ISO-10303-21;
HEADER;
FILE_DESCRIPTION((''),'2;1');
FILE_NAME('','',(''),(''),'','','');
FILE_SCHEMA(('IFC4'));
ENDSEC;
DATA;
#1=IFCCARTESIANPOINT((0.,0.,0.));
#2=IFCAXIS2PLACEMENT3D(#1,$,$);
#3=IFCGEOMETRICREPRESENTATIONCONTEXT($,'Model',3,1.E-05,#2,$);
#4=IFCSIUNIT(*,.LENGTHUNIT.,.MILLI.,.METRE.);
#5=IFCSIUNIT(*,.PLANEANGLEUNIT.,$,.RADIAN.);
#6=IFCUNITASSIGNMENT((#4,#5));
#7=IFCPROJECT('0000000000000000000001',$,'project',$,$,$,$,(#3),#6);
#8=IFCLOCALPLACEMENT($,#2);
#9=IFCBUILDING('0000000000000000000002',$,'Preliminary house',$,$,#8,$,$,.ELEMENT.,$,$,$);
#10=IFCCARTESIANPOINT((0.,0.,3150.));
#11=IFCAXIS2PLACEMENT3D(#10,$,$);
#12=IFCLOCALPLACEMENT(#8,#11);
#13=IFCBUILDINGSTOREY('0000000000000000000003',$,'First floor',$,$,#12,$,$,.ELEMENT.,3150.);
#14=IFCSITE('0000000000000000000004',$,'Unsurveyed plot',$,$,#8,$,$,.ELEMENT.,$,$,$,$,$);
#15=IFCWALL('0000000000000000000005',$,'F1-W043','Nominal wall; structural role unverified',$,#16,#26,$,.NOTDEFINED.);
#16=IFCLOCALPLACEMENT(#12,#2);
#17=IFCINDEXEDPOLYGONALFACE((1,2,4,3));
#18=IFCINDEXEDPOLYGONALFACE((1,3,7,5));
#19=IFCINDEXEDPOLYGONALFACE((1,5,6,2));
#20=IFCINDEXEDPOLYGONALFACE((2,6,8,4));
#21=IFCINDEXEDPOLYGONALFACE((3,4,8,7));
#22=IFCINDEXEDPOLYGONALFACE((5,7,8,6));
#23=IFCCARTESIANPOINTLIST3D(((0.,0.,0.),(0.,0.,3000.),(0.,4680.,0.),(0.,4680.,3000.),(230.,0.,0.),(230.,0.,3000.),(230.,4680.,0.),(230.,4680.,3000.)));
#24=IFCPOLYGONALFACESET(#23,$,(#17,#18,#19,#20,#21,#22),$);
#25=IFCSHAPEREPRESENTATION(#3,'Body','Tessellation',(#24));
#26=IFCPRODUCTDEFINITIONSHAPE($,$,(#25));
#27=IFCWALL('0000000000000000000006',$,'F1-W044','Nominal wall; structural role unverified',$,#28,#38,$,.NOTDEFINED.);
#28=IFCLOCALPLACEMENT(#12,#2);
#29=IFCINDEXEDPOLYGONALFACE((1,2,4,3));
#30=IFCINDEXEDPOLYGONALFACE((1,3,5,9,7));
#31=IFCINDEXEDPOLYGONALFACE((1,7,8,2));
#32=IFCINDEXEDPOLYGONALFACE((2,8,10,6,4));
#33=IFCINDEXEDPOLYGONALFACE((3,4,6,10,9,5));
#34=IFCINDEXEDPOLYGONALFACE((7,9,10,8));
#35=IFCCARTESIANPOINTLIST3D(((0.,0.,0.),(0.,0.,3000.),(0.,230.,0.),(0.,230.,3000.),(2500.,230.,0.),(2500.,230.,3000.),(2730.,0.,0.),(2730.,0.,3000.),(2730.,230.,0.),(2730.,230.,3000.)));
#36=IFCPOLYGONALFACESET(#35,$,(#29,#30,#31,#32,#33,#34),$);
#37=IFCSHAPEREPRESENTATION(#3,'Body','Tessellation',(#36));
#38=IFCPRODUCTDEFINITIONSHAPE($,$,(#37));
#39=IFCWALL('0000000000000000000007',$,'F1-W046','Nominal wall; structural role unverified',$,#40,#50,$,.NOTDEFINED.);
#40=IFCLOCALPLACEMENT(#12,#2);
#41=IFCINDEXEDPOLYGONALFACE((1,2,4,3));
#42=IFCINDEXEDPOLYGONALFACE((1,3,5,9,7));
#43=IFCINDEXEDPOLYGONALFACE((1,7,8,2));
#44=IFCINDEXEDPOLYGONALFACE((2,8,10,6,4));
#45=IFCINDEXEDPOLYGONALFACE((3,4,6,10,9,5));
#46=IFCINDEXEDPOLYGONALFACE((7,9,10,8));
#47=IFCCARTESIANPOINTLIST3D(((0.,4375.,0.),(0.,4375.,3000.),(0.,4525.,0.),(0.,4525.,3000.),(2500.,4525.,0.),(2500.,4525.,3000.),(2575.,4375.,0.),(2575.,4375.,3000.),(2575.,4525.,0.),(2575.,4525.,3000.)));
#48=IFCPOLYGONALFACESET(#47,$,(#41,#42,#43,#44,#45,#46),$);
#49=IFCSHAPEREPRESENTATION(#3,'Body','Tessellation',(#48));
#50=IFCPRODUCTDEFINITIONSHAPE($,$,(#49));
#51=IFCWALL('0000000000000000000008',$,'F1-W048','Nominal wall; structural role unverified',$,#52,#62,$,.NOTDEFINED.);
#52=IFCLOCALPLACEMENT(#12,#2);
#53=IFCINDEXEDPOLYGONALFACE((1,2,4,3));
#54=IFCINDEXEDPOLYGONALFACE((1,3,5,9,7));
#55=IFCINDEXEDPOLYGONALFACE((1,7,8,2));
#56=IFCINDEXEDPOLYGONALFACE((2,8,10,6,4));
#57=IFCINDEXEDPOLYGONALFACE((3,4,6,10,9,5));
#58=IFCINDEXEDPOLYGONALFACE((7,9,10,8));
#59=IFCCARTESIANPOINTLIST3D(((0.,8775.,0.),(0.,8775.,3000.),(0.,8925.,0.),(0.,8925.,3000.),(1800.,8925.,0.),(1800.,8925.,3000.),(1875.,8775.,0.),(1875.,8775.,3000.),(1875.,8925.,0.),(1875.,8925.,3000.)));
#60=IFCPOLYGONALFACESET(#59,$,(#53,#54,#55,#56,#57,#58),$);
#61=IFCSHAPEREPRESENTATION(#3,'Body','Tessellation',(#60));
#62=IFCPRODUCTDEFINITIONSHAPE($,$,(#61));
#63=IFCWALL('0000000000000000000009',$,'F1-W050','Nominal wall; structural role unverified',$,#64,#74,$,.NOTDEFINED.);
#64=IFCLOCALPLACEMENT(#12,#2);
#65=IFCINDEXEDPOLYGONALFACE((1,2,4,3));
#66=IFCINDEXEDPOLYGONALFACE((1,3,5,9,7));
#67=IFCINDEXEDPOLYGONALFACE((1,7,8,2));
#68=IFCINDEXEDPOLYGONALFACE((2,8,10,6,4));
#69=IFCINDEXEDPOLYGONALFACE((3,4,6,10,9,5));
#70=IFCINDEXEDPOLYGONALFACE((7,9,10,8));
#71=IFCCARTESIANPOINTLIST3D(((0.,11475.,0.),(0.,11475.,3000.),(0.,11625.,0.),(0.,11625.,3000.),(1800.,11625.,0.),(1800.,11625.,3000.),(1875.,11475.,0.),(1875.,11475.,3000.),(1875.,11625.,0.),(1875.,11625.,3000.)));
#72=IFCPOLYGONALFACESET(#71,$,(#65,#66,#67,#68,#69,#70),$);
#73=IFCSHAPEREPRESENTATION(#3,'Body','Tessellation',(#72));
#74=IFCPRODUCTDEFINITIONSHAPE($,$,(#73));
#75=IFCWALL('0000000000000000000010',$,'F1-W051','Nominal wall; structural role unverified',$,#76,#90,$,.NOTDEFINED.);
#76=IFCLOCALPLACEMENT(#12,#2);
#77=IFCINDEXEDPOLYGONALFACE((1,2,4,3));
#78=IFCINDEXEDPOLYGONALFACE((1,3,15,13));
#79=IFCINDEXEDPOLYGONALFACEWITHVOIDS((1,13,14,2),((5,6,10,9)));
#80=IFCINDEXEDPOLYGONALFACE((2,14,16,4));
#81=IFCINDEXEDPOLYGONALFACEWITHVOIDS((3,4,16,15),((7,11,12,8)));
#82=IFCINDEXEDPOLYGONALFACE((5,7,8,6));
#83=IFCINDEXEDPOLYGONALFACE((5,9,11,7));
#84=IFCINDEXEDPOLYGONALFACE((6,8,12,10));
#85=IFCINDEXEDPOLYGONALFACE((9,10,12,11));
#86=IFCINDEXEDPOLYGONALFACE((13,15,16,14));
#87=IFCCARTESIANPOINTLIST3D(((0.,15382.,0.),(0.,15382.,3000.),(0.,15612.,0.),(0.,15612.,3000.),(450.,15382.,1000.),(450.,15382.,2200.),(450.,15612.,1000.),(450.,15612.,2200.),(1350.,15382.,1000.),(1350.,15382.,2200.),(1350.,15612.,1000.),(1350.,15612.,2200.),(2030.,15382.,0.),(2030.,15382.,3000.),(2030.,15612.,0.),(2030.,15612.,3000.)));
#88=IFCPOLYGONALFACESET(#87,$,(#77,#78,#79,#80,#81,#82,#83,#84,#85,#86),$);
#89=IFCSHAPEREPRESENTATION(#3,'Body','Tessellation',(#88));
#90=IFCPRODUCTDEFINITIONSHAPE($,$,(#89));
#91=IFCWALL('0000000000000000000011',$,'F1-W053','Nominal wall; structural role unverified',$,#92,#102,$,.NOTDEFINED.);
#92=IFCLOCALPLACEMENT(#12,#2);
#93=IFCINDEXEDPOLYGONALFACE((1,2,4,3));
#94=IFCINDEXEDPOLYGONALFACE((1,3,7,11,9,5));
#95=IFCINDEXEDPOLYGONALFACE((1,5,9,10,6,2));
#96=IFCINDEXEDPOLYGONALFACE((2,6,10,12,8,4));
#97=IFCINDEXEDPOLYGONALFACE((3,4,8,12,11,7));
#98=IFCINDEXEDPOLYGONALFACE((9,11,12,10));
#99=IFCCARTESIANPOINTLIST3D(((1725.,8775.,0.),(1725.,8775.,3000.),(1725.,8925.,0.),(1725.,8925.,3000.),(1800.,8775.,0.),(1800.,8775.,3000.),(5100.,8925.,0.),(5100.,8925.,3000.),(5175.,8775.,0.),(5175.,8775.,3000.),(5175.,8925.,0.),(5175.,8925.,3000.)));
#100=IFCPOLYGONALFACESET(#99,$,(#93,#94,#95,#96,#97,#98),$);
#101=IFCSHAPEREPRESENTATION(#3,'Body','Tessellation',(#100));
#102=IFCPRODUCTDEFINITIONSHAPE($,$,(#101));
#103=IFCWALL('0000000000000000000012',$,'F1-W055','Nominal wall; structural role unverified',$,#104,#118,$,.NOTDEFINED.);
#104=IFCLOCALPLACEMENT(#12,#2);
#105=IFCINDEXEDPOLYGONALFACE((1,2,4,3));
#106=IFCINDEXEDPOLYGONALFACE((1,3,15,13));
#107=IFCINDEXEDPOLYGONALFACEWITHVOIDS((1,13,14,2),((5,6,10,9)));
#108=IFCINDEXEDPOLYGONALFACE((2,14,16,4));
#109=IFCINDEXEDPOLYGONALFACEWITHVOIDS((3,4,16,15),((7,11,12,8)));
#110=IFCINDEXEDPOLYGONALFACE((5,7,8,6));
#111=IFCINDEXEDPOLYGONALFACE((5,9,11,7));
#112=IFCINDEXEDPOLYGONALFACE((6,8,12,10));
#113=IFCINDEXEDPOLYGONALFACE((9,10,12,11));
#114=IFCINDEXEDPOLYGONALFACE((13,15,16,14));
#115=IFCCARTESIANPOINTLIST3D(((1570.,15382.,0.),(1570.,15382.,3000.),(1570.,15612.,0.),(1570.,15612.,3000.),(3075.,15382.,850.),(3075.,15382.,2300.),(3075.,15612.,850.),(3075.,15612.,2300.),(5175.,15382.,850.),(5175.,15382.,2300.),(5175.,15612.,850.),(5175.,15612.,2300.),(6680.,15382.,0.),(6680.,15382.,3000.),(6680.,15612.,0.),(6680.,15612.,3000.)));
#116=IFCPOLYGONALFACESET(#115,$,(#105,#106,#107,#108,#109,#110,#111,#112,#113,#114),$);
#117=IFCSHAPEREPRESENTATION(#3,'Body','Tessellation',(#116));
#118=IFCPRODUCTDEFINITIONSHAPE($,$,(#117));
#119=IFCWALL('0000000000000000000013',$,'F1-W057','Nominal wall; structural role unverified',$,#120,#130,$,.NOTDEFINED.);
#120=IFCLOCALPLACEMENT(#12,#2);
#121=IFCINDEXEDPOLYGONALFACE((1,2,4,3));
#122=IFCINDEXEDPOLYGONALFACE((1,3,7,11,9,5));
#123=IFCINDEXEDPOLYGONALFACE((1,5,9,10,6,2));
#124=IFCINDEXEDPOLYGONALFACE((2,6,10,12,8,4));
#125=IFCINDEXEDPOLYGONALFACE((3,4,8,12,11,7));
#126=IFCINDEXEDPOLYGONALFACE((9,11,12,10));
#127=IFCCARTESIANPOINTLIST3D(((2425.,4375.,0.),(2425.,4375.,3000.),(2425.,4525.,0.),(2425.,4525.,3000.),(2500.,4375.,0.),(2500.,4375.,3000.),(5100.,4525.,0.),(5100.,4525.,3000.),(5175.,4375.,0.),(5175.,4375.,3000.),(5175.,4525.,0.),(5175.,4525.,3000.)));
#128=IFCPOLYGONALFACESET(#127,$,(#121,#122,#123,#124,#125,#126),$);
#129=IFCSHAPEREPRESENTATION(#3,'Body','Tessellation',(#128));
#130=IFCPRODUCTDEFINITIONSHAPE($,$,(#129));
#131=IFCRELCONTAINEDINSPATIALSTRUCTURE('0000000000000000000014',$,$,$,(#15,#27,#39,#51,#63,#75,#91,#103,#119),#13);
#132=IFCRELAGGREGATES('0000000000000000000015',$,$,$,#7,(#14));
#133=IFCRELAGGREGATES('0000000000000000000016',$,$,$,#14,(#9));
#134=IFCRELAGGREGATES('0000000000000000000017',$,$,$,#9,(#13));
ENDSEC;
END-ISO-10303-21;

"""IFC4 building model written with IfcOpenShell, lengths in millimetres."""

from ifc_helpers import new_model, si_unit, frame, origin, place, context, project, spatial, polyline, outline, extrude, element, save


model = new_model("IFC4")

# Units and contexts
model_context = context("Model", 3, precision=1e-05, world=origin())
ifc_project = project(units=[si_unit("LENGTHUNIT", "METRE", prefix="MILLI"), si_unit("PLANEANGLEUNIT", "RADIAN")], contexts=[model_context])

# Site, building, storey
placement_1 = place(None, origin())
site = spatial("IfcSite", under=ifc_project, at=placement_1, Name="Unsurveyed plot", CompositionType="ELEMENT")
building = spatial("IfcBuilding", under=site, at=placement_1, Name="Preliminary house", CompositionType="ELEMENT")
placement_2 = place(placement_1, frame((0.0, 0.0, 3150.0)))
storey = spatial("IfcBuildingStorey", under=building, at=placement_2, Name="First floor", CompositionType="ELEMENT", Elevation=3150.0)

# Walls
element("IfcWall", 1, at=placement_2, inside=storey, Name="F1-W043", Description="Nominal wall; structural role unverified", PredefinedType="NOTDEFINED", context=model_context, shape_type="SweptSolid", body=[
    extrude(outline(polyline([(230.0, 4680.0), (230.0, 0.0), (0.0, 0.0), (0.0, 4680.0), (230.0, 4680.0)])), origin(), (0.0, 0.0, 1.0), 3000.0),
])
element("IfcWall", 2, at=placement_2, inside=storey, Name="F1-W044", Description="Nominal wall; structural role unverified", PredefinedType="NOTDEFINED", context=model_context, shape_type="SweptSolid", body=[
    extrude(outline(polyline([(2730.0, 230.0), (2730.0, 0.0), (0.0, 0.0), (0.0, 230.0), (2500.0, 230.0), (2730.0, 230.0)])), origin(), (0.0, 0.0, 1.0), 3000.0),
])

# Wall
element("IfcWall", 3, at=placement_2, inside=storey, Name="F1-W046", Description="Nominal wall; structural role unverified", PredefinedType="NOTDEFINED", context=model_context, shape_type="SweptSolid", body=[
    extrude(outline(polyline([(2575.0, 4525.0), (2575.0, 4375.0), (0.0, 4375.0), (0.0, 4525.0), (2500.0, 4525.0), (2575.0, 4525.0)])), origin(), (0.0, 0.0, 1.0), 3000.0),
])

# Wall
element("IfcWall", 4, at=placement_2, inside=storey, Name="F1-W048", Description="Nominal wall; structural role unverified", PredefinedType="NOTDEFINED", context=model_context, shape_type="SweptSolid", body=[
    extrude(outline(polyline([(1875.0, 8925.0), (1875.0, 8775.0), (0.0, 8775.0), (0.0, 8925.0), (1800.0, 8925.0), (1875.0, 8925.0)])), origin(), (0.0, 0.0, 1.0), 3000.0),
])

# Wall
element("IfcWall", 5, at=placement_2, inside=storey, Name="F1-W050", Description="Nominal wall; structural role unverified", PredefinedType="NOTDEFINED", context=model_context, shape_type="SweptSolid", body=[
    extrude(outline(polyline([(1875.0, 11625.0), (1875.0, 11475.0), (0.0, 11475.0), (0.0, 11625.0), (1800.0, 11625.0), (1875.0, 11625.0)])), origin(), (0.0, 0.0, 1.0), 3000.0),
])

# Wall, opening
wall_1 = element("IfcWall", 6, at=placement_2, inside=storey, Name="F1-W051", Description="Nominal wall; structural role unverified", PredefinedType="NOTDEFINED", context=model_context, shape_type="SweptSolid", body=[
    extrude(outline(polyline([(2030.0, 15382.0), (0.0, 15382.0), (0.0, 15612.0), (2030.0, 15612.0), (2030.0, 15382.0)])), origin(), (0.0, 0.0, 1.0), 3000.0),
])
element("IfcOpeningElement", 7, at=placement_2, cuts=wall_1, PredefinedType="OPENING", context=model_context, shape_type="SweptSolid", body=[
    extrude(outline(polyline([(450.0, 14967.0), (1350.0, 14967.0), (1350.0, 16027.0), (450.0, 16027.0), (450.0, 14967.0)])), frame((0.0, 0.0, 1000.0)), (0.0, 0.0, 1.0), 1200.0),
])

# Wall
element("IfcWall", 8, at=placement_2, inside=storey, Name="F1-W053", Description="Nominal wall; structural role unverified", PredefinedType="NOTDEFINED", context=model_context, shape_type="SweptSolid", body=[
    extrude(outline(polyline([(5175.0, 8925.0), (5175.0, 8775.0), (1800.0, 8775.0), (1725.0, 8775.0), (1725.0, 8925.0), (5100.0, 8925.0), (5175.0, 8925.0)])), origin(), (0.0, 0.0, 1.0), 3000.0),
])

# Wall, opening
wall_2 = element("IfcWall", 9, at=placement_2, inside=storey, Name="F1-W055", Description="Nominal wall; structural role unverified", PredefinedType="NOTDEFINED", context=model_context, shape_type="SweptSolid", body=[
    extrude(outline(polyline([(6680.0, 15382.0), (1800.0, 15382.0), (1570.0, 15382.0), (1570.0, 15612.0), (6680.0, 15612.0), (6680.0, 15382.0)])), origin(), (0.0, 0.0, 1.0), 3000.0),
])
element("IfcOpeningElement", 10, at=placement_2, cuts=wall_2, PredefinedType="OPENING", context=model_context, shape_type="SweptSolid", body=[
    extrude(outline(polyline([(3075.0, 14967.0), (5175.0, 14967.0), (5175.0, 16027.0), (3075.0, 16027.0), (3075.0, 14967.0)])), frame((0.0, 0.0, 850.0)), (0.0, 0.0, 1.0), 1450.0),
])

# Wall
element("IfcWall", 11, at=placement_2, inside=storey, Name="F1-W057", Description="Nominal wall; structural role unverified", PredefinedType="NOTDEFINED", context=model_context, shape_type="SweptSolid", body=[
    extrude(outline(polyline([(5175.0, 4525.0), (5175.0, 4375.0), (2500.0, 4375.0), (2425.0, 4375.0), (2425.0, 4525.0), (5100.0, 4525.0), (5175.0, 4525.0)])), origin(), (0.0, 0.0, 1.0), 3000.0),
])

save(model, "model.ifc")
